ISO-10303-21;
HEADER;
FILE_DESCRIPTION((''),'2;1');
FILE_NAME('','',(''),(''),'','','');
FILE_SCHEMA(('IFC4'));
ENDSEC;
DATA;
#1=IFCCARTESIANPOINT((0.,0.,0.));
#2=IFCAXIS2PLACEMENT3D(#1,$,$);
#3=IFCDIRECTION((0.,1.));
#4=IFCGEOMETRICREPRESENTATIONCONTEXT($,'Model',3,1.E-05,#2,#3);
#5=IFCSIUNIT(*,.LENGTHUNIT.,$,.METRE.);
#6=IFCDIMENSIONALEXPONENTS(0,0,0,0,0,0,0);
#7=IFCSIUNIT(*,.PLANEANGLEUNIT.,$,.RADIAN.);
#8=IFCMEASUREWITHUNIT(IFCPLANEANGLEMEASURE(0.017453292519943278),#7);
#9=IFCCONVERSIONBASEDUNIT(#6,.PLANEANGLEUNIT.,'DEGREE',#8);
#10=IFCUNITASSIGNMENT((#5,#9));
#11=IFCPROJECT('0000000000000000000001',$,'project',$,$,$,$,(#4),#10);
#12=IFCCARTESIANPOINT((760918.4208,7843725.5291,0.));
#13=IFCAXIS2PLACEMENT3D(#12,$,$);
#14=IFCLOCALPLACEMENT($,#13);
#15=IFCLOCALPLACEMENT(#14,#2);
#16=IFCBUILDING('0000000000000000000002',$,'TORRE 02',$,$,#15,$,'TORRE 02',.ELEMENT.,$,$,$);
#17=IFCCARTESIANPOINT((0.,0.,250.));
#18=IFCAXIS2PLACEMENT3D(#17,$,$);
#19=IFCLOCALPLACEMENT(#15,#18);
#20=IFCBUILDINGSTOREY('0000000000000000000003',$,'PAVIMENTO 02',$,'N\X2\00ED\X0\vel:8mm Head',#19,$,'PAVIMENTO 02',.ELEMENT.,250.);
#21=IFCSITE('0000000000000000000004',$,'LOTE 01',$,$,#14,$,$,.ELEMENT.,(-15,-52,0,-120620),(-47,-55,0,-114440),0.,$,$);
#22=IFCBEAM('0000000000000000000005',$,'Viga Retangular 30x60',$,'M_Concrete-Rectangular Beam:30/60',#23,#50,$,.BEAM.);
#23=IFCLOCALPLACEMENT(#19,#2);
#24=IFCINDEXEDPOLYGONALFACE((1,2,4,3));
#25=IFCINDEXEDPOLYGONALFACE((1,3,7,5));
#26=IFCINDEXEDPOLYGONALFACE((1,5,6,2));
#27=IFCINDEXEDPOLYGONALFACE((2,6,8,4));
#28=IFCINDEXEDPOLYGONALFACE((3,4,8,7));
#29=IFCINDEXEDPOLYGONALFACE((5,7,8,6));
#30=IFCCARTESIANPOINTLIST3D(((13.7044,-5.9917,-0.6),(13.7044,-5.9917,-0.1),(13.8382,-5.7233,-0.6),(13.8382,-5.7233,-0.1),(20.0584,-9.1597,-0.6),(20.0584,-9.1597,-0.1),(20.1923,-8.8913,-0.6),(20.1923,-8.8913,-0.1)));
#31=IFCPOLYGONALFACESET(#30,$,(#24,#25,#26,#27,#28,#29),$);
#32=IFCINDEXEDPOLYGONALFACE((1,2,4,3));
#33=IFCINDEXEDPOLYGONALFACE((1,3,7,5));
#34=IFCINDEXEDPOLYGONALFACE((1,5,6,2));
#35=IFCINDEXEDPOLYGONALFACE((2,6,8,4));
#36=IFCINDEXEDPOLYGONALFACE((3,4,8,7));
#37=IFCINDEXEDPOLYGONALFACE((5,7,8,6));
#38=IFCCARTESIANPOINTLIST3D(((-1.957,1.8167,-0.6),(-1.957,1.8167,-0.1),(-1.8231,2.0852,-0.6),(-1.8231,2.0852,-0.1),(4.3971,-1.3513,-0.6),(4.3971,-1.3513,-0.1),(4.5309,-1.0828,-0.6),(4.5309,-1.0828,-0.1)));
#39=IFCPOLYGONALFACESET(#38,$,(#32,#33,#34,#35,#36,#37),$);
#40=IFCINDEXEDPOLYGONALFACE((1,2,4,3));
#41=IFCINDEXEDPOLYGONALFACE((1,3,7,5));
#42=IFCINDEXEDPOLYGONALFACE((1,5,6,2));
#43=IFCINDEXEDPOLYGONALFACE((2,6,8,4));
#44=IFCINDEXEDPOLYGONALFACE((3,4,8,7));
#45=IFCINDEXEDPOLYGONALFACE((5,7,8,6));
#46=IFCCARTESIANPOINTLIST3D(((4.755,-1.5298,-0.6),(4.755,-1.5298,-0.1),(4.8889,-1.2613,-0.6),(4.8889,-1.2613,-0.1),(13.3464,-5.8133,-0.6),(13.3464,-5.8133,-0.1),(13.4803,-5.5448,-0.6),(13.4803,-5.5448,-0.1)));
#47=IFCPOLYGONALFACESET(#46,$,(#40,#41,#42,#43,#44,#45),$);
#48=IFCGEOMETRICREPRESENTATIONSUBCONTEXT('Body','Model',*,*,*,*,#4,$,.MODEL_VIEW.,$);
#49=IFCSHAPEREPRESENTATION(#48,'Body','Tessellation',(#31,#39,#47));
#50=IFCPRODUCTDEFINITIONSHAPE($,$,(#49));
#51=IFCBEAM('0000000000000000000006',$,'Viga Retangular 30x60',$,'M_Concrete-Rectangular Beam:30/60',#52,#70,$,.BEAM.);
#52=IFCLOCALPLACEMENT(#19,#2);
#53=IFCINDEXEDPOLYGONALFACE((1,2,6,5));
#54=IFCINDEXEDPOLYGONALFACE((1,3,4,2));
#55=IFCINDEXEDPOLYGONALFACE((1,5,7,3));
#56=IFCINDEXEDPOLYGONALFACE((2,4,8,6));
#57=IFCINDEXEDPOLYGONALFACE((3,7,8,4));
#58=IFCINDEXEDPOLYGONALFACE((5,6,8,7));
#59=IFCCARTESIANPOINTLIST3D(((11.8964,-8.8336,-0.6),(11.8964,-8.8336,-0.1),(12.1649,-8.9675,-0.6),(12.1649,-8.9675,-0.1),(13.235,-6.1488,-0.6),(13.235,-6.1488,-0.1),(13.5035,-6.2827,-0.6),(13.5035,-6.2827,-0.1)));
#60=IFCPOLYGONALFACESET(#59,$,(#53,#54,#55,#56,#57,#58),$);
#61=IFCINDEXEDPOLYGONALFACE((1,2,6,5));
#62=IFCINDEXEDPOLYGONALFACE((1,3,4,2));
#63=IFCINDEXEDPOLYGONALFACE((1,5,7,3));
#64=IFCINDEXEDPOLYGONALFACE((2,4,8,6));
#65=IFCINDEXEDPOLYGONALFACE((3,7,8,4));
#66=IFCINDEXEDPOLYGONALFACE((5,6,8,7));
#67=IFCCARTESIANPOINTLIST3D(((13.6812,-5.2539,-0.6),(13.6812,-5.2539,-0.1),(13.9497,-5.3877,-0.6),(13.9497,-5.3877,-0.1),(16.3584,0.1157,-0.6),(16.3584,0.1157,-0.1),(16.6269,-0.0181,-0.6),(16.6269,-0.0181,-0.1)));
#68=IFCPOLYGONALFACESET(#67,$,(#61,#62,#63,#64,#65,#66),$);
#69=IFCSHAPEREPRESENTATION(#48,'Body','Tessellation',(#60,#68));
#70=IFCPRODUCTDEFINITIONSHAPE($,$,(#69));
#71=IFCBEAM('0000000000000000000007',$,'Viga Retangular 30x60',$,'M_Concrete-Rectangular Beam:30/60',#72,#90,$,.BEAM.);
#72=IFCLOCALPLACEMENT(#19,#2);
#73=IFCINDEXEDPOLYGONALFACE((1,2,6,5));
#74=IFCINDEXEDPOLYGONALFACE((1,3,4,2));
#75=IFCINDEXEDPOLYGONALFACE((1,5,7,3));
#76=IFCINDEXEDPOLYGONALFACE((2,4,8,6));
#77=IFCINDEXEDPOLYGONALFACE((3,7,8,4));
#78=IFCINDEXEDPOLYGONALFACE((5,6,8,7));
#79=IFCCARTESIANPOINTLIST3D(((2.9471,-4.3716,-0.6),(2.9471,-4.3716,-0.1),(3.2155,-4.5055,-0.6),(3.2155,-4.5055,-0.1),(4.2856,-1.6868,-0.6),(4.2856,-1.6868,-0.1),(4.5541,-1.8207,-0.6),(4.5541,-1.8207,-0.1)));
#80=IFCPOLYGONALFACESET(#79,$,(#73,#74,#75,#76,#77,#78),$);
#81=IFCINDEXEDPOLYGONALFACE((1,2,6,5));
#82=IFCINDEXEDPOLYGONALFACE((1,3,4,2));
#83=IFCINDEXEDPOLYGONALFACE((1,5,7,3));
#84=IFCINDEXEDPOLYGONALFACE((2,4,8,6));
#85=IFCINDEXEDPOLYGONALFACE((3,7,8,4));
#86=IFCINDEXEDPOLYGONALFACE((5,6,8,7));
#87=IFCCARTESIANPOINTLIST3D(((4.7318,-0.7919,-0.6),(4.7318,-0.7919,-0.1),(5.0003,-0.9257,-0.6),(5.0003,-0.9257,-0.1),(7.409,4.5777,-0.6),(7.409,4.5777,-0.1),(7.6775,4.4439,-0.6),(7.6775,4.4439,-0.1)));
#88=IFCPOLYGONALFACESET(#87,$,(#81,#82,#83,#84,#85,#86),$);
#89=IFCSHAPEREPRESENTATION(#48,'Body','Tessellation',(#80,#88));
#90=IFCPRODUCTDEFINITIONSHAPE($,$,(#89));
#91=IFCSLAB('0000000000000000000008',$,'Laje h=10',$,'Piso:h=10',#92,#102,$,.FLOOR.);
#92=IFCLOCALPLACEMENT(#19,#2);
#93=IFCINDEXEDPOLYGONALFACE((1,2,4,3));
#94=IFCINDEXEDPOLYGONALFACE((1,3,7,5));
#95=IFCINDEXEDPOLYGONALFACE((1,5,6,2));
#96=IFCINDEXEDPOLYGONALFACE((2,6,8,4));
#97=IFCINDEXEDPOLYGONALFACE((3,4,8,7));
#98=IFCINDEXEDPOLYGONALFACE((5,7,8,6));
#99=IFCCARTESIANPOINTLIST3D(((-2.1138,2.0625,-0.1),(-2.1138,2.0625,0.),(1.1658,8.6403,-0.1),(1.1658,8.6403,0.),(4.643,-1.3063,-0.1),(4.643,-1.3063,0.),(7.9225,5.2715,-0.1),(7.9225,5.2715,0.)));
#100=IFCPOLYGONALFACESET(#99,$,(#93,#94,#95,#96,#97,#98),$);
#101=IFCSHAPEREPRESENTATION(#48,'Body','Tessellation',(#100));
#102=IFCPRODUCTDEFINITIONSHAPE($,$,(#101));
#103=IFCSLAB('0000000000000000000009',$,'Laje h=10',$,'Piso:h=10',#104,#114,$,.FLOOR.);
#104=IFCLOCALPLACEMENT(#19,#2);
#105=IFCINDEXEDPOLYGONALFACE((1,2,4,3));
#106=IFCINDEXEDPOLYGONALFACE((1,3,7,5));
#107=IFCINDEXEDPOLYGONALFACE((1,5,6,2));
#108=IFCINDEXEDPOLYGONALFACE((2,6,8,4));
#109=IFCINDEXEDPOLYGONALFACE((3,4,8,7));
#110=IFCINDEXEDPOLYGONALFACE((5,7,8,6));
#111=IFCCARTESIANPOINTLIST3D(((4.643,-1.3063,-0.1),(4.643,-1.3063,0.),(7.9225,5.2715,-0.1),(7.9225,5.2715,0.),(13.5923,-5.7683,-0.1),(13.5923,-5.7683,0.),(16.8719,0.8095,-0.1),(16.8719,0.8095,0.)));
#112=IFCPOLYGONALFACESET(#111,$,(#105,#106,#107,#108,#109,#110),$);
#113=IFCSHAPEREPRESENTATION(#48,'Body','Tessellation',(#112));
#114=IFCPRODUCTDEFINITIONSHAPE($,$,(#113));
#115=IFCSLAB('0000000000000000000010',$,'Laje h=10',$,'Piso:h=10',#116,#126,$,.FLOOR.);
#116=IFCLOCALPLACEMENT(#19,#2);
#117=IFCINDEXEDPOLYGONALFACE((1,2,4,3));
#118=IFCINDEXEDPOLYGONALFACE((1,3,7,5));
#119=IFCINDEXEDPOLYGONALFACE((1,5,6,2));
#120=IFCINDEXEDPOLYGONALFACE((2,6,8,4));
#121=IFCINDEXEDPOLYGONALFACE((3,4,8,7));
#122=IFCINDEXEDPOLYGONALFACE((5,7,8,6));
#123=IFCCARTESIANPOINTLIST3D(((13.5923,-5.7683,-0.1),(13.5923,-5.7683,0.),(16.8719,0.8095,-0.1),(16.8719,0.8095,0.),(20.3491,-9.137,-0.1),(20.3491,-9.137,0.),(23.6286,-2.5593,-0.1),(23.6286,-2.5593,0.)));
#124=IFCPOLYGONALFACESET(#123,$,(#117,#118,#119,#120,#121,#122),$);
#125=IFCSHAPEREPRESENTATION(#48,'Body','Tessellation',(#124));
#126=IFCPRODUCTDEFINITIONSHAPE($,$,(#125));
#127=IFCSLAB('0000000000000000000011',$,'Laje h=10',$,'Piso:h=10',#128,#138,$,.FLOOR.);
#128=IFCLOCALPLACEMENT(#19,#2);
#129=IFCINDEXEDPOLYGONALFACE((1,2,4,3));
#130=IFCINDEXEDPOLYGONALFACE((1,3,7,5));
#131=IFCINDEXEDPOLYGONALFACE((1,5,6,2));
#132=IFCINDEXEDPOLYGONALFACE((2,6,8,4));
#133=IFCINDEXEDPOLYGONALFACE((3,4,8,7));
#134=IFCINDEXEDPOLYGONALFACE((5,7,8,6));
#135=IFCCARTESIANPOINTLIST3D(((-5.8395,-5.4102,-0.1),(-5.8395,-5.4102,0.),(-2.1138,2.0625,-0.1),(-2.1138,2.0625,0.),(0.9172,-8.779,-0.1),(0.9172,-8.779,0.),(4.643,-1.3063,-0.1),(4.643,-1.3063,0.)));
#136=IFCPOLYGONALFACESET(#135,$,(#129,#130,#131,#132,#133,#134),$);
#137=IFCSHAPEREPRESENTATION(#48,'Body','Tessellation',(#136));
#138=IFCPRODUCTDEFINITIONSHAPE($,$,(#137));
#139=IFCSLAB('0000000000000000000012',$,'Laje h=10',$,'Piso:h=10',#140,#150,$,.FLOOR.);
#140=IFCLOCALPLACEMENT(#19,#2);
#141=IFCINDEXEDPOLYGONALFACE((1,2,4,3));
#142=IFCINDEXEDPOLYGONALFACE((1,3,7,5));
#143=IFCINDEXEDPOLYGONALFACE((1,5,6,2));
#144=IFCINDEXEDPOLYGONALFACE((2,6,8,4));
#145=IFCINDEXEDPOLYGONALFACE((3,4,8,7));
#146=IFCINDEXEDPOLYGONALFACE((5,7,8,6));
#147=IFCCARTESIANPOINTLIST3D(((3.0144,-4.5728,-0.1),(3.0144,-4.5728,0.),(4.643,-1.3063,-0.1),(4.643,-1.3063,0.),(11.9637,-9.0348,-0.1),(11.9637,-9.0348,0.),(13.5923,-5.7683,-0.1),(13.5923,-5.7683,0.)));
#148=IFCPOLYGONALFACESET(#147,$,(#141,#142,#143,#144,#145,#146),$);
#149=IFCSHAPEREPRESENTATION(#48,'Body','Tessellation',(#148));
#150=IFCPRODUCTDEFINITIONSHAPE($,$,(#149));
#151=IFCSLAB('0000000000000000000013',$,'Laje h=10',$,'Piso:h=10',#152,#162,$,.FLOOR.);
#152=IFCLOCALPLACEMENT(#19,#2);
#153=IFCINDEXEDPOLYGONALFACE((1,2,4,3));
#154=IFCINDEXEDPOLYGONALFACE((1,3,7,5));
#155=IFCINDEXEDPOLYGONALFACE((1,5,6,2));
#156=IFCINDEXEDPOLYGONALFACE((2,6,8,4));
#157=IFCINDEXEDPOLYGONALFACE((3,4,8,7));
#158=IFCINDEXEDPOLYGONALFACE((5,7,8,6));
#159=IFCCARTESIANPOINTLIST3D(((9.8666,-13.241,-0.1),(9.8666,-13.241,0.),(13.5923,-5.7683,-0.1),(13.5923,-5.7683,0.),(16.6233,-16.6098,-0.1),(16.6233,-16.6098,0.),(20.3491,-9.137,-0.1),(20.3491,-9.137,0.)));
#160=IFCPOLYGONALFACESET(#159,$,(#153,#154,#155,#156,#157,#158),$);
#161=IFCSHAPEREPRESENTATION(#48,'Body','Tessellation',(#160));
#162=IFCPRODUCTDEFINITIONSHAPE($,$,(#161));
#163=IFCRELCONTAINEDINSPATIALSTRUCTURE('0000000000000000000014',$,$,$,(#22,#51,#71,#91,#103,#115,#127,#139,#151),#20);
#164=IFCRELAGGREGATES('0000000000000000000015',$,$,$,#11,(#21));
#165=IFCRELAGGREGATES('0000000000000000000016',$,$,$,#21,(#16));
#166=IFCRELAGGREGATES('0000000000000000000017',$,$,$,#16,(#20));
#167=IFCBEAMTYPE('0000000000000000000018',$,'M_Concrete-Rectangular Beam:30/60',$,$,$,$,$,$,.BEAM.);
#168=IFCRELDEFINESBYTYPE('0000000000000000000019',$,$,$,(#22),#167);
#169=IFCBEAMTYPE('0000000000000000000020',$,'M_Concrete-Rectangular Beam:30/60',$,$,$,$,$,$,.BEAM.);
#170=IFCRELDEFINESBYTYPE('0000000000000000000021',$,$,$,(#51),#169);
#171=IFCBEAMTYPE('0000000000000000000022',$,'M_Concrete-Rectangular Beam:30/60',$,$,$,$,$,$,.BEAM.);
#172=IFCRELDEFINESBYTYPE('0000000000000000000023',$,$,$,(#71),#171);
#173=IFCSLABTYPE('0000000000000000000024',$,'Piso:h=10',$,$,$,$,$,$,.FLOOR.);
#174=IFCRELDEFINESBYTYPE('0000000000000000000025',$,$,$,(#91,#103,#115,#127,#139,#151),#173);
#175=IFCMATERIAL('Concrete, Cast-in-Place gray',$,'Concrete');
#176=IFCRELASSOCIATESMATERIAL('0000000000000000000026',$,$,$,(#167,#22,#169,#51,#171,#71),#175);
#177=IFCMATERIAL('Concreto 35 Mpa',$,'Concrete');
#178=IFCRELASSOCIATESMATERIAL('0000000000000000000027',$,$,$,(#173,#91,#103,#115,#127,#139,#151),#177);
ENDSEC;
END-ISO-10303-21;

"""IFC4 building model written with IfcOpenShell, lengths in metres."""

from ifc_helpers import new_model, entity, si_unit, converted_unit, direction, frame, origin, place, context, subcontext, project, spatial, indexed_curve, outline, extrude, source, transform, mapped, material, type_object, type_shapes, element, save


model = new_model("IFC4")

# Units and contexts
model_context = context("Model", 3, precision=1e-05, world=origin(), true_north=direction((0.0, 1.0)))
body_context = subcontext(model_context, "Body", "Model", "MODEL_VIEW")
ifc_project = project(units=[si_unit("LENGTHUNIT", "METRE"), converted_unit("PLANEANGLEUNIT", "DEGREE", entity("IfcPlaneAngleMeasure", 0.017453292519943278), si_unit("PLANEANGLEUNIT", "RADIAN"), dimensions=[0, 0, 0, 0, 0, 0, 0])], contexts=[model_context])

# Site, building, storey
site_placement = place(None, frame((760918.4208, 7843725.5291, 0.0)))
site = spatial("IfcSite", under=ifc_project, at=site_placement, Name="LOTE 01", CompositionType="ELEMENT", RefLatitude=(-15, -52, 0, -120620), RefLongitude=(-47, -55, 0, -114440), RefElevation=0.0)
building_placement = place(site_placement, origin())
building = spatial("IfcBuilding", under=site, at=building_placement, Name="TORRE 02", LongName="TORRE 02", CompositionType="ELEMENT")
storey_placement = place(building_placement, frame((0.0, 0.0, 250.0)))
storey = spatial("IfcBuildingStorey", under=building, at=storey_placement, Name="PAVIMENTO 02", ObjectType="Nível:8mm Head", LongName="PAVIMENTO 02", CompositionType="ELEMENT", Elevation=250.0)

# Shared definitions
ifc_material_1 = material(Name="Concrete, Cast-in-Place gray", Category="Concrete")

# Beams
beam_type_1 = type_object("IfcBeamType", Name="M_Concrete-Rectangular Beam:30/60", PredefinedType="BEAM", material=ifc_material_1)
shared_shape_1 = source(origin(), body_context, "Body", "SweptSolid", [
    extrude(outline(indexed_curve([(-0.25, -0.15), (0.25, -0.15), (0.25, 0.15), (-0.25, 0.15), (-0.25, -0.15)], self_intersect=False)), frame((13.7713, -5.8575, 249.65), z_axis=(0.894934, -0.446198, 0.0), x_axis=(0.0, 0.0, -1.0)), (0.0, 0.0, 1.0), 7.1),
    extrude(outline(indexed_curve([(-0.25, -0.15), (0.25, -0.15), (0.25, 0.15), (-0.25, 0.15), (-0.25, -0.15)], self_intersect=False)), frame((-1.89, 1.951, 249.65), z_axis=(0.894934, -0.446198, 0.0), x_axis=(0.0, 0.0, -1.0)), (0.0, 0.0, 1.0), 7.1),
    extrude(outline(indexed_curve([(-0.25, -0.15), (0.25, -0.15), (0.25, 0.15), (-0.25, 0.15), (-0.25, -0.15)], self_intersect=False)), frame((4.822, -1.3955, 249.65), z_axis=(0.894934, -0.446198, 0.0), x_axis=(0.0, 0.0, -1.0)), (0.0, 0.0, 1.0), 9.6),
])
type_shapes(beam_type_1, [shared_shape_1])
beam_1_placement = place(storey_placement, frame((0.0, 0.0, -250.0)))
element("IfcBeam", 1, at=beam_1_placement, inside=storey, type_object=beam_type_1, material=ifc_material_1, Name="Viga Retangular 30x60", ObjectType="M_Concrete-Rectangular Beam:30/60", PredefinedType="BEAM", context=body_context, shape_type="MappedRepresentation", body=[
    mapped(shared_shape_1, transform((0.0, 0.0, 0.0), scale=1.0)),
])
beam_type_2 = type_object("IfcBeamType", Name="M_Concrete-Rectangular Beam:30/60", PredefinedType="BEAM", material=ifc_material_1)
shared_shape_2 = source(origin(), body_context, "Body", "SweptSolid", [
    extrude(outline(indexed_curve([(-0.25, -0.15), (0.25, -0.15), (0.25, 0.15), (-0.25, 0.15), (-0.25, -0.15)], self_intersect=False)), frame((12.0306, -8.9005, 249.65), z_axis=(0.446198, 0.894934, 0.0), x_axis=(0.0, 0.0, 1.0)), (0.0, 0.0, 1.0), 3.0),
    extrude(outline(indexed_curve([(-0.25, -0.15), (0.25, -0.15), (0.25, 0.15), (-0.25, 0.15), (-0.25, -0.15)], self_intersect=False)), frame((13.8154, -5.3208, 249.65), z_axis=(0.446198, 0.894934, 0.0), x_axis=(0.0, 0.0, 1.0)), (0.0, 0.0, 1.0), 6.0),
])
type_shapes(beam_type_2, [shared_shape_2])
beam_2_placement = place(storey_placement, frame((0.0, 0.0, -250.0)))
element("IfcBeam", 2, at=beam_2_placement, inside=storey, type_object=beam_type_2, material=ifc_material_1, Name="Viga Retangular 30x60", ObjectType="M_Concrete-Rectangular Beam:30/60", PredefinedType="BEAM", context=body_context, shape_type="MappedRepresentation", body=[
    mapped(shared_shape_2, transform((0.0, 0.0, 0.0), scale=1.0)),
])
beam_type_3 = type_object("IfcBeamType", Name="M_Concrete-Rectangular Beam:30/60", PredefinedType="BEAM", material=ifc_material_1)
shared_shape_3 = source(origin(), body_context, "Body", "SweptSolid", [
    extrude(outline(indexed_curve([(-0.25, -0.15), (0.25, -0.15), (0.25, 0.15), (-0.25, 0.15), (-0.25, -0.15)], self_intersect=False)), frame((3.0813, -4.4385, 249.65), z_axis=(0.446198, 0.894934, 0.0), x_axis=(0.0, 0.0, 1.0)), (0.0, 0.0, 1.0), 3.0),
    extrude(outline(indexed_curve([(-0.25, -0.15), (0.25, -0.15), (0.25, 0.15), (-0.25, 0.15), (-0.25, -0.15)], self_intersect=False)), frame((4.8661, -0.8588, 249.65), z_axis=(0.446198, 0.894934, 0.0), x_axis=(0.0, 0.0, 1.0)), (0.0, 0.0, 1.0), 6.0),
])
type_shapes(beam_type_3, [shared_shape_3])
beam_3_placement = place(storey_placement, frame((0.0, 0.0, -250.0)))
element("IfcBeam", 3, at=beam_3_placement, inside=storey, type_object=beam_type_3, material=ifc_material_1, Name="Viga Retangular 30x60", ObjectType="M_Concrete-Rectangular Beam:30/60", PredefinedType="BEAM", context=body_context, shape_type="MappedRepresentation", body=[
    mapped(shared_shape_3, transform((0.0, 0.0, 0.0), scale=1.0)),
])

# Slabs
ifc_material_2 = material(Name="Concreto 35 Mpa", Category="Concrete")
slab_type = type_object("IfcSlabType", Name="Piso:h=10", PredefinedType="FLOOR", material=ifc_material_2)
slab_1_placement = place(storey_placement, origin())
element("IfcSlab", 4, at=slab_1_placement, inside=storey, type_object=slab_type, material=ifc_material_2, Name="Laje h=10", ObjectType="Piso:h=10", PredefinedType="FLOOR", context=body_context, shape_type="SweptSolid", body=[
    extrude(outline(indexed_curve([(-3.675, -3.775), (3.675, -3.775), (3.675, 3.775), (-3.675, 3.775), (-3.675, -3.775)], self_intersect=False)), frame((2.9044, 3.667, 0.0), z_axis=(0.0, 0.0, -1.0), x_axis=(-0.446198, -0.894934, 0.0)), (0.0, 0.0, 1.0), 0.1),
])
slab_2_placement = place(storey_placement, origin())
element("IfcSlab", 5, at=slab_2_placement, inside=storey, type_object=slab_type, material=ifc_material_2, Name="Laje h=10", ObjectType="Piso:h=10", PredefinedType="FLOOR", context=body_context, shape_type="SweptSolid", body=[
    extrude(outline(indexed_curve([(-3.675, -5.0), (3.675, -5.0), (3.675, 5.0), (-3.675, 5.0), (-3.675, -5.0)], self_intersect=False)), frame((10.7574, -0.2484, 0.0), z_axis=(0.0, 0.0, -1.0), x_axis=(-0.446198, -0.894934, 0.0)), (0.0, 0.0, 1.0), 0.1),
])
slab_3_placement = place(storey_placement, origin())
element("IfcSlab", 6, at=slab_3_placement, inside=storey, type_object=slab_type, material=ifc_material_2, Name="Laje h=10", ObjectType="Piso:h=10", PredefinedType="FLOOR", context=body_context, shape_type="SweptSolid", body=[
    extrude(outline(indexed_curve([(-3.675, -3.775), (3.675, -3.775), (3.675, 3.775), (-3.675, 3.775), (-3.675, -3.775)], self_intersect=False)), frame((18.6105, -4.1638, 0.0), z_axis=(0.0, 0.0, -1.0), x_axis=(-0.446198, -0.894934, 0.0)), (0.0, 0.0, 1.0), 0.1),
])
slab_4_placement = place(storey_placement, origin())
element("IfcSlab", 7, at=slab_4_placement, inside=storey, type_object=slab_type, material=ifc_material_2, Name="Laje h=10", ObjectType="Piso:h=10", PredefinedType="FLOOR", context=body_context, shape_type="SweptSolid", body=[
    extrude(outline(indexed_curve([(-4.175, -3.775), (4.175, -3.775), (4.175, 3.775), (-4.175, 3.775), (-4.175, -3.775)], self_intersect=False)), frame((-0.5983, -3.3582, 0.0), z_axis=(0.0, 0.0, -1.0), x_axis=(-0.446198, -0.894934, 0.0)), (0.0, 0.0, 1.0), 0.1),
])
slab_5_placement = place(storey_placement, origin())
element("IfcSlab", 8, at=slab_5_placement, inside=storey, type_object=slab_type, material=ifc_material_2, Name="Laje h=10", ObjectType="Piso:h=10", PredefinedType="FLOOR", context=body_context, shape_type="SweptSolid", body=[
    extrude(outline(indexed_curve([(-1.825, -5.0), (1.825, -5.0), (1.825, 5.0), (-1.825, 5.0), (-1.825, -5.0)], self_intersect=False)), frame((8.3033, -5.1705, 0.0), z_axis=(0.0, 0.0, -1.0), x_axis=(-0.446198, -0.894934, 0.0)), (0.0, 0.0, 1.0), 0.1),
])
slab_6_placement = place(storey_placement, origin())
element("IfcSlab", 9, at=slab_6_placement, inside=storey, type_object=slab_type, material=ifc_material_2, Name="Laje h=10", ObjectType="Piso:h=10", PredefinedType="FLOOR", context=body_context, shape_type="SweptSolid", body=[
    extrude(outline(indexed_curve([(-4.175, -3.775), (4.175, -3.775), (4.175, 3.775), (-4.175, 3.775), (-4.175, -3.775)], self_intersect=False)), frame((15.1078, -11.189, 0.0), z_axis=(0.0, 0.0, -1.0), x_axis=(-0.446198, -0.894934, 0.0)), (0.0, 0.0, 1.0), 0.1),
])

save(model, "model.ifc")
